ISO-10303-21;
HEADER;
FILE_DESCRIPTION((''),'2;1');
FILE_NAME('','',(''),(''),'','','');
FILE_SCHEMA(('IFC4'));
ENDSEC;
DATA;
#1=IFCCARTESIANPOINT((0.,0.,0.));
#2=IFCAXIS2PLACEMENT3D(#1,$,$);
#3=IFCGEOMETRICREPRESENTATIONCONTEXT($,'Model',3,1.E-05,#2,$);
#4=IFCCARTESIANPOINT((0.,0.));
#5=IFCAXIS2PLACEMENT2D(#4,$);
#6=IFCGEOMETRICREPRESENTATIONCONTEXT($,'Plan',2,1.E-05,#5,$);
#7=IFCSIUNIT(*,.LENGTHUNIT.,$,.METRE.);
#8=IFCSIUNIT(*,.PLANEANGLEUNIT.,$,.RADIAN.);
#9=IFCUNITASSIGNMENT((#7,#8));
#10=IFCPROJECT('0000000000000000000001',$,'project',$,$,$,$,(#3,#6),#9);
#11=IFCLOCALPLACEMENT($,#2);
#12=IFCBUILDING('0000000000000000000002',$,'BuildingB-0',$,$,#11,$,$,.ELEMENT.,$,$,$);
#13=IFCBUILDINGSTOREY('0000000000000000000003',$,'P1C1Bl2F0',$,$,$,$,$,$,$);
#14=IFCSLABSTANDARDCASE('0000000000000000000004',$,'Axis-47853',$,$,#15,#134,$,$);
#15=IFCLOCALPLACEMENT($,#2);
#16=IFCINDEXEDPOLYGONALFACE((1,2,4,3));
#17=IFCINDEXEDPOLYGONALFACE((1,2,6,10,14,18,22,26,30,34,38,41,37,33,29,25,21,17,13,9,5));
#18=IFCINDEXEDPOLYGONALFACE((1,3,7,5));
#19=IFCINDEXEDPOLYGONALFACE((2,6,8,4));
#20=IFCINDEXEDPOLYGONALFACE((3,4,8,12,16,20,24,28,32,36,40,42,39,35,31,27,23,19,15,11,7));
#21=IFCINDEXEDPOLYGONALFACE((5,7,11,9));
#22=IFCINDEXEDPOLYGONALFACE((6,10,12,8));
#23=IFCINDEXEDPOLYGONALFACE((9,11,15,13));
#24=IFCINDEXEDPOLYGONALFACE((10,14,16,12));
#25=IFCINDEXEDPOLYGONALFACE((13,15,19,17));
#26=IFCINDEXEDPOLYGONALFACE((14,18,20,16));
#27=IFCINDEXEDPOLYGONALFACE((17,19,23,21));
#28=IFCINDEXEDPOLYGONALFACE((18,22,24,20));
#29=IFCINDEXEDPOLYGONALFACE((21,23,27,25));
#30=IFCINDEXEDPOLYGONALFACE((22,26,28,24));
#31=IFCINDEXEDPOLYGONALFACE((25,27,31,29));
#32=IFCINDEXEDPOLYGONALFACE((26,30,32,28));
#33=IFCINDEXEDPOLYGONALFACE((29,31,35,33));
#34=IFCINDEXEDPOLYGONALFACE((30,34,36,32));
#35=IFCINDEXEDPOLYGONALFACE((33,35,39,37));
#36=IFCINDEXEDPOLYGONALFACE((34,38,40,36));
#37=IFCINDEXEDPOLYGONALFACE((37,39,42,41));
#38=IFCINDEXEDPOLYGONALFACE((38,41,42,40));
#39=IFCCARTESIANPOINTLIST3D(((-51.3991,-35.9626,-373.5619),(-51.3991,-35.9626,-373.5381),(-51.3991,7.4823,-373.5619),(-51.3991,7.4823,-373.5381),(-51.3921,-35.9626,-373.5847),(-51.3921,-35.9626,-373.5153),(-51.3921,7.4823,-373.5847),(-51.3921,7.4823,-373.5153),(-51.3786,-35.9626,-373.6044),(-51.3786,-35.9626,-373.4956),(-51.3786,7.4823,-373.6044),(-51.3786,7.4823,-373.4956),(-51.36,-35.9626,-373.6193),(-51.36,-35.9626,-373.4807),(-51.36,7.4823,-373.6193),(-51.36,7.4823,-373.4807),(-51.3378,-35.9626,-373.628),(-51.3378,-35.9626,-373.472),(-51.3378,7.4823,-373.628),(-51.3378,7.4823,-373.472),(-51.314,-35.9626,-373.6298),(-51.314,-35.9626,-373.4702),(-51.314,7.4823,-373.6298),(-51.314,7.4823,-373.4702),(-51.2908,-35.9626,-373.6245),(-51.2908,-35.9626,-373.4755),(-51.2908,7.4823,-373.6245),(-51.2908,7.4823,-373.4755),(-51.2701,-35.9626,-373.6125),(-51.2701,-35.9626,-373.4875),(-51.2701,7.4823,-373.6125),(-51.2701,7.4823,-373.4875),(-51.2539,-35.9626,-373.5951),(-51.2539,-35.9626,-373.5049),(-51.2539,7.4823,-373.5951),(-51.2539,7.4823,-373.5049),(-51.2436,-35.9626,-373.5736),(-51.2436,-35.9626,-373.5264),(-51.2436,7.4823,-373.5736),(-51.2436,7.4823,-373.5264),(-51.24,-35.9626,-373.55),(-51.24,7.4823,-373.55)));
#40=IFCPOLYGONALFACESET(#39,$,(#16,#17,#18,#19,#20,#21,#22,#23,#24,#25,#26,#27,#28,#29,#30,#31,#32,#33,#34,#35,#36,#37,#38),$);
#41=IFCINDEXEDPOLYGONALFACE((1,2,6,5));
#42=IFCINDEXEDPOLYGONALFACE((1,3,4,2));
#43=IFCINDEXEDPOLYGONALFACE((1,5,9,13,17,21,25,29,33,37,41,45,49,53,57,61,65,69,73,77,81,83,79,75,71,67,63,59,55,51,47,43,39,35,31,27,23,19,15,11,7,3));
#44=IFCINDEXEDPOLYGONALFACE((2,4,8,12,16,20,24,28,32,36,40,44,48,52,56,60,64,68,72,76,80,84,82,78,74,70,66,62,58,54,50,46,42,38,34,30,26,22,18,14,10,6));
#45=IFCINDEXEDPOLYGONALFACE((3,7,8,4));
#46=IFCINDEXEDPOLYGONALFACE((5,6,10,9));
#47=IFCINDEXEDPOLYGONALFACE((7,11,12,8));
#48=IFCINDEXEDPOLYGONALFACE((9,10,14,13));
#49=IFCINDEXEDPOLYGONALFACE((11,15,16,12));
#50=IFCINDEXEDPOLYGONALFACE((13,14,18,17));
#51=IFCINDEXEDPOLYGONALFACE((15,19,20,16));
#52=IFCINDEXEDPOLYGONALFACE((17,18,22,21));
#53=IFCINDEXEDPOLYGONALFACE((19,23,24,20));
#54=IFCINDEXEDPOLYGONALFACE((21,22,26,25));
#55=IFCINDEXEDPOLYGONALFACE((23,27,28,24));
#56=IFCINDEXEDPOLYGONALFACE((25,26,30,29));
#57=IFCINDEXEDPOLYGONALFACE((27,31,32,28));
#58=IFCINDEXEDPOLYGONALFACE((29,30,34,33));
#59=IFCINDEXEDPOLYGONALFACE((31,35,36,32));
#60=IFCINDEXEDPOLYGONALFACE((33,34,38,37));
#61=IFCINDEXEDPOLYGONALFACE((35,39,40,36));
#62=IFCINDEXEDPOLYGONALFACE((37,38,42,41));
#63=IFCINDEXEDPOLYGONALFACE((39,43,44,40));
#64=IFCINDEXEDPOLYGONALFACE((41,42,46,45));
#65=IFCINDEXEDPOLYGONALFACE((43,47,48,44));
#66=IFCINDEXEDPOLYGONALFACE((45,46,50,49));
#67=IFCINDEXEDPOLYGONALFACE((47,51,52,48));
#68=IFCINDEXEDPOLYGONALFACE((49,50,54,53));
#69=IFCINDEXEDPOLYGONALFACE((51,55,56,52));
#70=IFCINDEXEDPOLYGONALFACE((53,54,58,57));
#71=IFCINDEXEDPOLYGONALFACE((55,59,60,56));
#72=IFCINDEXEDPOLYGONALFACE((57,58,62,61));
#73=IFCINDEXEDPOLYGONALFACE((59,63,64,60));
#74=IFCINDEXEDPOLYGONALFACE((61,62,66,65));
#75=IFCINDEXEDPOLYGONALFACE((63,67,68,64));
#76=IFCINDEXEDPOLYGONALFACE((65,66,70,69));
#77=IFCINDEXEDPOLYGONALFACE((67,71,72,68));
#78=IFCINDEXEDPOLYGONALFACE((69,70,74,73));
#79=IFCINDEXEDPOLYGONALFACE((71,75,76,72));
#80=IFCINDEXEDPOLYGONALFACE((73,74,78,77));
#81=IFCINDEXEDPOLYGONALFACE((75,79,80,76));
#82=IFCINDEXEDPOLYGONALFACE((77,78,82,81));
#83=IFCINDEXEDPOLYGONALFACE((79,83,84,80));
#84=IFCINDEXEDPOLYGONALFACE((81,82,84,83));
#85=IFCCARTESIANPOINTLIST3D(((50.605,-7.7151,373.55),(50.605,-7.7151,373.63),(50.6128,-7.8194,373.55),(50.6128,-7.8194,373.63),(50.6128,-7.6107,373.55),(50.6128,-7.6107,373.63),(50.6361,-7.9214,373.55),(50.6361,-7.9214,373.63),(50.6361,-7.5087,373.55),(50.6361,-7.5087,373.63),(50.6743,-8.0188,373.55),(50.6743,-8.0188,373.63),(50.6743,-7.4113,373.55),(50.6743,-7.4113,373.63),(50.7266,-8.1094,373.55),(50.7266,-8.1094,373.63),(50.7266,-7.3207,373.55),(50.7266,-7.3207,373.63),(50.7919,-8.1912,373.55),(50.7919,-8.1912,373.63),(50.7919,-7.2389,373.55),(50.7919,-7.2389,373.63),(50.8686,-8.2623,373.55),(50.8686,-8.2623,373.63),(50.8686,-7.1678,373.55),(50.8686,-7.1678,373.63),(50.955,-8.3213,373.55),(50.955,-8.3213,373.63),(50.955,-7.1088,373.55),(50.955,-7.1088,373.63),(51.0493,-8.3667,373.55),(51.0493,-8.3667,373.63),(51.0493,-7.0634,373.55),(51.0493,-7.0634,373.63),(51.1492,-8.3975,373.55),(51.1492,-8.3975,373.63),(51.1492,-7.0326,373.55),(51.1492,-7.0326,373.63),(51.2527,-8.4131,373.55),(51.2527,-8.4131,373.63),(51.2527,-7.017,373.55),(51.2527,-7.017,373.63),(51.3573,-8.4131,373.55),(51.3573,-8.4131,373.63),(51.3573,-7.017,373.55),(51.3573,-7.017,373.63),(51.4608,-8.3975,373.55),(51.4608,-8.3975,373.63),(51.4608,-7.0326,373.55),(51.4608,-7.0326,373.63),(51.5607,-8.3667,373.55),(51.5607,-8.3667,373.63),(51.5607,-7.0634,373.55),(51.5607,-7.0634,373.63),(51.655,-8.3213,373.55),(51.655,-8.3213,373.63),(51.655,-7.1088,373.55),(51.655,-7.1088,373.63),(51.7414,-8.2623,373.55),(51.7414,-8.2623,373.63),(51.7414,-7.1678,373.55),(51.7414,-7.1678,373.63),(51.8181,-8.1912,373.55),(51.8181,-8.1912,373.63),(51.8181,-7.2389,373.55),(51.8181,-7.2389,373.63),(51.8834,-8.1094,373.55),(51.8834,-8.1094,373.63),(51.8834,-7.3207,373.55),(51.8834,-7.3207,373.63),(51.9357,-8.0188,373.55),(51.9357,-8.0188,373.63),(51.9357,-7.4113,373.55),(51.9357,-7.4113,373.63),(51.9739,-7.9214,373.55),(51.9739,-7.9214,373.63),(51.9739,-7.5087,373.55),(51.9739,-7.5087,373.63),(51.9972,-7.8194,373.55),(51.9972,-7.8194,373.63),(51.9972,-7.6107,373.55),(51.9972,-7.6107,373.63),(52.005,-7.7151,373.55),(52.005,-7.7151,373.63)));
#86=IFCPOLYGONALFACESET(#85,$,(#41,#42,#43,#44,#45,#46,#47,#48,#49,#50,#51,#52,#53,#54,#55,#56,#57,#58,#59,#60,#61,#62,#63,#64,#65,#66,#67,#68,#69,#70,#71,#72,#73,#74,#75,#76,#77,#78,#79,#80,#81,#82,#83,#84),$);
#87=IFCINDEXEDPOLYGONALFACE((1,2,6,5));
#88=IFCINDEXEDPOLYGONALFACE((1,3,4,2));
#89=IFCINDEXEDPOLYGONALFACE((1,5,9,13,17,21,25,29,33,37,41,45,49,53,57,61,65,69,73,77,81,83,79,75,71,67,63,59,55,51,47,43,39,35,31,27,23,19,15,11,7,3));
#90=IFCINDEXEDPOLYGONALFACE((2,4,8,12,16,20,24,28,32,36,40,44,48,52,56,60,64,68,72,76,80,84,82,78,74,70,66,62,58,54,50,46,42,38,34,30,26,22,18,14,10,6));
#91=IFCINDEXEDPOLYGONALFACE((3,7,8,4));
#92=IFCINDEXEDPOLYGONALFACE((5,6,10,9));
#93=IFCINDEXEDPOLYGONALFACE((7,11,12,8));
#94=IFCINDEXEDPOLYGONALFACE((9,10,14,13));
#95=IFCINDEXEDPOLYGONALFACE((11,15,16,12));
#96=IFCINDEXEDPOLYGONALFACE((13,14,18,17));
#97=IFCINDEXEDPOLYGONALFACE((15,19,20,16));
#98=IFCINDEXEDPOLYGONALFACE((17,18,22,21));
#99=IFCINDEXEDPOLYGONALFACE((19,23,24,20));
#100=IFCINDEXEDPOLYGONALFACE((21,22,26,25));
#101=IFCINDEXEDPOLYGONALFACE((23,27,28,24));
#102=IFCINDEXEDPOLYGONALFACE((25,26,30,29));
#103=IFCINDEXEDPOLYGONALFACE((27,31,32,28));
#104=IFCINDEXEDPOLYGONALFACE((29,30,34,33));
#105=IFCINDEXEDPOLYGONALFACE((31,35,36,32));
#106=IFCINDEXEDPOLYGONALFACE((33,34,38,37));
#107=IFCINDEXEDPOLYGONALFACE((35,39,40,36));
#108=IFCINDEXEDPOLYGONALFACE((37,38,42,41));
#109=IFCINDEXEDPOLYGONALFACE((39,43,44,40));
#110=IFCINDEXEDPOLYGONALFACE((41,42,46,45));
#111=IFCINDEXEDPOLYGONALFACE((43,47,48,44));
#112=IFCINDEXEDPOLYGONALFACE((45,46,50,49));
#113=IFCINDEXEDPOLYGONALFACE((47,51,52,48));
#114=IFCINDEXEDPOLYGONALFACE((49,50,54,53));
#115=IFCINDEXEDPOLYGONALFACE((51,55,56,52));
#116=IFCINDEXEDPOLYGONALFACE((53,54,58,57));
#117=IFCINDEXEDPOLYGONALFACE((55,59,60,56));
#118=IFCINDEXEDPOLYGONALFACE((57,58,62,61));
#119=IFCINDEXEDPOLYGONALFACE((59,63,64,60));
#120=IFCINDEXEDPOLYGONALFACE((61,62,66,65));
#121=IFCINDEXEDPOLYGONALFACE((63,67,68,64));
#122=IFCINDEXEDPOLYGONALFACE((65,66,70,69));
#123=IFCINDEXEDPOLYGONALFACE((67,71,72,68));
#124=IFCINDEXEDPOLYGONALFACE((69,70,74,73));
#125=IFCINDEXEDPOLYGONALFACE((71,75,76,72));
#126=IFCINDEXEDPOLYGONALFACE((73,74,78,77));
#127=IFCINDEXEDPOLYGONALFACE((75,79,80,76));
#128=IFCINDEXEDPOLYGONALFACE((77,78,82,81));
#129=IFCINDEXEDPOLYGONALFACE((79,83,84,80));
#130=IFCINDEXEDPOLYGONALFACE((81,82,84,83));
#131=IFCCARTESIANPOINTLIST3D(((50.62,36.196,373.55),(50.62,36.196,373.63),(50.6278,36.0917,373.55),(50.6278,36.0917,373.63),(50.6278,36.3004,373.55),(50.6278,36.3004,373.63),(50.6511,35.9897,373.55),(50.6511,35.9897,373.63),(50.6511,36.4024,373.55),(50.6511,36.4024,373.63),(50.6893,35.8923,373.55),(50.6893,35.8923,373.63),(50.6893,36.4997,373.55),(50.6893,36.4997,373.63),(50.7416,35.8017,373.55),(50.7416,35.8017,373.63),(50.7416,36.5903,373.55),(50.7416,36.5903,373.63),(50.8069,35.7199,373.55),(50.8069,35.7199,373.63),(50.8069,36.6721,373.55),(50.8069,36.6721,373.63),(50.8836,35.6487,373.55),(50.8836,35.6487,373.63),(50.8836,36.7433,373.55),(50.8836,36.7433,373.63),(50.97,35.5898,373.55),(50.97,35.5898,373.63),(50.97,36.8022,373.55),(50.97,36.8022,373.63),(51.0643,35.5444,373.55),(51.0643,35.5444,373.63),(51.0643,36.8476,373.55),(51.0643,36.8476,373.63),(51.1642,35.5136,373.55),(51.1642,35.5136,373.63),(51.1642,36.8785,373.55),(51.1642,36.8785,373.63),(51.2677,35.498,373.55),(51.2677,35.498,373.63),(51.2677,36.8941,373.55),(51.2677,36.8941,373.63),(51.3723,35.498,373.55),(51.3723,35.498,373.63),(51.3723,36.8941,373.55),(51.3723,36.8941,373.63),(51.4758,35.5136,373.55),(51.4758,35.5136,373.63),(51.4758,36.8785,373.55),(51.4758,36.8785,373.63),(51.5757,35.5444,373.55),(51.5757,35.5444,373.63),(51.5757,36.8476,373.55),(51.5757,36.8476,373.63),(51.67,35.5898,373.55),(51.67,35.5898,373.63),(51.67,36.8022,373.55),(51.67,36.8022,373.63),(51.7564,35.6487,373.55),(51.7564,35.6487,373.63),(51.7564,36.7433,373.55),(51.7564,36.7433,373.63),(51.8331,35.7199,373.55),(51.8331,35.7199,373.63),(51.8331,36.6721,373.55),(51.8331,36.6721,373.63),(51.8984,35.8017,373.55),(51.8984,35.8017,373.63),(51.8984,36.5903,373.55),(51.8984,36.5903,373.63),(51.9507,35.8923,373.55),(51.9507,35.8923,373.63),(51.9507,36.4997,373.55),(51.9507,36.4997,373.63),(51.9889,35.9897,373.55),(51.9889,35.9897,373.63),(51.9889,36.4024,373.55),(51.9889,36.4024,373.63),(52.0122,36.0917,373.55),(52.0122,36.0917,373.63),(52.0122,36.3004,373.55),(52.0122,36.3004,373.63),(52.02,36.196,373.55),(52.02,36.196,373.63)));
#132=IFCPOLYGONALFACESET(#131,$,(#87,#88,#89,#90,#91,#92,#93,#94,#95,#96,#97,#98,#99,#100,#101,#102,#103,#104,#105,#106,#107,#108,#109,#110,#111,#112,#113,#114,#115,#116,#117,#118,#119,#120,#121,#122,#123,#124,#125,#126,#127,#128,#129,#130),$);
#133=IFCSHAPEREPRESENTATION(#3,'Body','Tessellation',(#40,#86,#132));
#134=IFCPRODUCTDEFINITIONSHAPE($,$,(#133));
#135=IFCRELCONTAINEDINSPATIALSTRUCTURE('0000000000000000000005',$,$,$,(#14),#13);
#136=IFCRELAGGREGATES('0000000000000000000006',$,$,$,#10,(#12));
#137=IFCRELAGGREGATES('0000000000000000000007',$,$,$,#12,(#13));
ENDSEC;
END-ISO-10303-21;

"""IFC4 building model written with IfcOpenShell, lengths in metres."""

from ifc_helpers import new_model, entity, si_unit, frame, origin, origin_2d, place, context, project, spatial, circle, extrude, element, save


model = new_model("IFC4")

# Units and contexts
model_context = context("Model", 3, precision=1e-05, world=origin())
plan_context = context("Plan", 2, precision=1e-05, world=origin_2d())
ifc_project = project(units=[si_unit("LENGTHUNIT", "METRE"), si_unit("PLANEANGLEUNIT", "RADIAN")], contexts=[model_context, plan_context])

# Building, storey
building_placement = place(None, origin())
building = spatial("IfcBuilding", under=ifc_project, at=building_placement, Name="BuildingB-0", CompositionType="ELEMENT")
storey = spatial("IfcBuildingStorey", under=building, Name="P1C1Bl2F0")

# Slab
element("IfcSlabStandardCase", 1, inside=storey, Name="Axis-47853", context=model_context, shape_type="AdvancedSweptSolid", body=[
    entity("IfcSurfaceCurveSweptAreaSolid", entity("IfcCircleProfileDef", "AREA", None, None, 0.08), None, entity("IfcPolyline", [entity("IfcCartesianPoint", [51.32, -7.4823, 373.55]), entity("IfcCartesianPoint", [51.32, 35.9626, 373.55])]), None, None, entity("IfcPlane", entity("IfcAxis2Placement3D", entity("IfcCartesianPoint", [51.32, -7.4823, 373.55]), entity("IfcDirection", [0.0, 0.0, 1.0]), entity("IfcDirection", [1.0, 0.0, 0.0])))),
    extrude(circle(Radius=0.7), frame((51.305, -7.7151, 373.55)), (0.0, 0.0, 1.0), 0.08),
    extrude(circle(Radius=0.7), frame((51.32, 36.196, 373.55)), (0.0, 0.0, 1.0), 0.08),
])

save(model, "model.ifc")
